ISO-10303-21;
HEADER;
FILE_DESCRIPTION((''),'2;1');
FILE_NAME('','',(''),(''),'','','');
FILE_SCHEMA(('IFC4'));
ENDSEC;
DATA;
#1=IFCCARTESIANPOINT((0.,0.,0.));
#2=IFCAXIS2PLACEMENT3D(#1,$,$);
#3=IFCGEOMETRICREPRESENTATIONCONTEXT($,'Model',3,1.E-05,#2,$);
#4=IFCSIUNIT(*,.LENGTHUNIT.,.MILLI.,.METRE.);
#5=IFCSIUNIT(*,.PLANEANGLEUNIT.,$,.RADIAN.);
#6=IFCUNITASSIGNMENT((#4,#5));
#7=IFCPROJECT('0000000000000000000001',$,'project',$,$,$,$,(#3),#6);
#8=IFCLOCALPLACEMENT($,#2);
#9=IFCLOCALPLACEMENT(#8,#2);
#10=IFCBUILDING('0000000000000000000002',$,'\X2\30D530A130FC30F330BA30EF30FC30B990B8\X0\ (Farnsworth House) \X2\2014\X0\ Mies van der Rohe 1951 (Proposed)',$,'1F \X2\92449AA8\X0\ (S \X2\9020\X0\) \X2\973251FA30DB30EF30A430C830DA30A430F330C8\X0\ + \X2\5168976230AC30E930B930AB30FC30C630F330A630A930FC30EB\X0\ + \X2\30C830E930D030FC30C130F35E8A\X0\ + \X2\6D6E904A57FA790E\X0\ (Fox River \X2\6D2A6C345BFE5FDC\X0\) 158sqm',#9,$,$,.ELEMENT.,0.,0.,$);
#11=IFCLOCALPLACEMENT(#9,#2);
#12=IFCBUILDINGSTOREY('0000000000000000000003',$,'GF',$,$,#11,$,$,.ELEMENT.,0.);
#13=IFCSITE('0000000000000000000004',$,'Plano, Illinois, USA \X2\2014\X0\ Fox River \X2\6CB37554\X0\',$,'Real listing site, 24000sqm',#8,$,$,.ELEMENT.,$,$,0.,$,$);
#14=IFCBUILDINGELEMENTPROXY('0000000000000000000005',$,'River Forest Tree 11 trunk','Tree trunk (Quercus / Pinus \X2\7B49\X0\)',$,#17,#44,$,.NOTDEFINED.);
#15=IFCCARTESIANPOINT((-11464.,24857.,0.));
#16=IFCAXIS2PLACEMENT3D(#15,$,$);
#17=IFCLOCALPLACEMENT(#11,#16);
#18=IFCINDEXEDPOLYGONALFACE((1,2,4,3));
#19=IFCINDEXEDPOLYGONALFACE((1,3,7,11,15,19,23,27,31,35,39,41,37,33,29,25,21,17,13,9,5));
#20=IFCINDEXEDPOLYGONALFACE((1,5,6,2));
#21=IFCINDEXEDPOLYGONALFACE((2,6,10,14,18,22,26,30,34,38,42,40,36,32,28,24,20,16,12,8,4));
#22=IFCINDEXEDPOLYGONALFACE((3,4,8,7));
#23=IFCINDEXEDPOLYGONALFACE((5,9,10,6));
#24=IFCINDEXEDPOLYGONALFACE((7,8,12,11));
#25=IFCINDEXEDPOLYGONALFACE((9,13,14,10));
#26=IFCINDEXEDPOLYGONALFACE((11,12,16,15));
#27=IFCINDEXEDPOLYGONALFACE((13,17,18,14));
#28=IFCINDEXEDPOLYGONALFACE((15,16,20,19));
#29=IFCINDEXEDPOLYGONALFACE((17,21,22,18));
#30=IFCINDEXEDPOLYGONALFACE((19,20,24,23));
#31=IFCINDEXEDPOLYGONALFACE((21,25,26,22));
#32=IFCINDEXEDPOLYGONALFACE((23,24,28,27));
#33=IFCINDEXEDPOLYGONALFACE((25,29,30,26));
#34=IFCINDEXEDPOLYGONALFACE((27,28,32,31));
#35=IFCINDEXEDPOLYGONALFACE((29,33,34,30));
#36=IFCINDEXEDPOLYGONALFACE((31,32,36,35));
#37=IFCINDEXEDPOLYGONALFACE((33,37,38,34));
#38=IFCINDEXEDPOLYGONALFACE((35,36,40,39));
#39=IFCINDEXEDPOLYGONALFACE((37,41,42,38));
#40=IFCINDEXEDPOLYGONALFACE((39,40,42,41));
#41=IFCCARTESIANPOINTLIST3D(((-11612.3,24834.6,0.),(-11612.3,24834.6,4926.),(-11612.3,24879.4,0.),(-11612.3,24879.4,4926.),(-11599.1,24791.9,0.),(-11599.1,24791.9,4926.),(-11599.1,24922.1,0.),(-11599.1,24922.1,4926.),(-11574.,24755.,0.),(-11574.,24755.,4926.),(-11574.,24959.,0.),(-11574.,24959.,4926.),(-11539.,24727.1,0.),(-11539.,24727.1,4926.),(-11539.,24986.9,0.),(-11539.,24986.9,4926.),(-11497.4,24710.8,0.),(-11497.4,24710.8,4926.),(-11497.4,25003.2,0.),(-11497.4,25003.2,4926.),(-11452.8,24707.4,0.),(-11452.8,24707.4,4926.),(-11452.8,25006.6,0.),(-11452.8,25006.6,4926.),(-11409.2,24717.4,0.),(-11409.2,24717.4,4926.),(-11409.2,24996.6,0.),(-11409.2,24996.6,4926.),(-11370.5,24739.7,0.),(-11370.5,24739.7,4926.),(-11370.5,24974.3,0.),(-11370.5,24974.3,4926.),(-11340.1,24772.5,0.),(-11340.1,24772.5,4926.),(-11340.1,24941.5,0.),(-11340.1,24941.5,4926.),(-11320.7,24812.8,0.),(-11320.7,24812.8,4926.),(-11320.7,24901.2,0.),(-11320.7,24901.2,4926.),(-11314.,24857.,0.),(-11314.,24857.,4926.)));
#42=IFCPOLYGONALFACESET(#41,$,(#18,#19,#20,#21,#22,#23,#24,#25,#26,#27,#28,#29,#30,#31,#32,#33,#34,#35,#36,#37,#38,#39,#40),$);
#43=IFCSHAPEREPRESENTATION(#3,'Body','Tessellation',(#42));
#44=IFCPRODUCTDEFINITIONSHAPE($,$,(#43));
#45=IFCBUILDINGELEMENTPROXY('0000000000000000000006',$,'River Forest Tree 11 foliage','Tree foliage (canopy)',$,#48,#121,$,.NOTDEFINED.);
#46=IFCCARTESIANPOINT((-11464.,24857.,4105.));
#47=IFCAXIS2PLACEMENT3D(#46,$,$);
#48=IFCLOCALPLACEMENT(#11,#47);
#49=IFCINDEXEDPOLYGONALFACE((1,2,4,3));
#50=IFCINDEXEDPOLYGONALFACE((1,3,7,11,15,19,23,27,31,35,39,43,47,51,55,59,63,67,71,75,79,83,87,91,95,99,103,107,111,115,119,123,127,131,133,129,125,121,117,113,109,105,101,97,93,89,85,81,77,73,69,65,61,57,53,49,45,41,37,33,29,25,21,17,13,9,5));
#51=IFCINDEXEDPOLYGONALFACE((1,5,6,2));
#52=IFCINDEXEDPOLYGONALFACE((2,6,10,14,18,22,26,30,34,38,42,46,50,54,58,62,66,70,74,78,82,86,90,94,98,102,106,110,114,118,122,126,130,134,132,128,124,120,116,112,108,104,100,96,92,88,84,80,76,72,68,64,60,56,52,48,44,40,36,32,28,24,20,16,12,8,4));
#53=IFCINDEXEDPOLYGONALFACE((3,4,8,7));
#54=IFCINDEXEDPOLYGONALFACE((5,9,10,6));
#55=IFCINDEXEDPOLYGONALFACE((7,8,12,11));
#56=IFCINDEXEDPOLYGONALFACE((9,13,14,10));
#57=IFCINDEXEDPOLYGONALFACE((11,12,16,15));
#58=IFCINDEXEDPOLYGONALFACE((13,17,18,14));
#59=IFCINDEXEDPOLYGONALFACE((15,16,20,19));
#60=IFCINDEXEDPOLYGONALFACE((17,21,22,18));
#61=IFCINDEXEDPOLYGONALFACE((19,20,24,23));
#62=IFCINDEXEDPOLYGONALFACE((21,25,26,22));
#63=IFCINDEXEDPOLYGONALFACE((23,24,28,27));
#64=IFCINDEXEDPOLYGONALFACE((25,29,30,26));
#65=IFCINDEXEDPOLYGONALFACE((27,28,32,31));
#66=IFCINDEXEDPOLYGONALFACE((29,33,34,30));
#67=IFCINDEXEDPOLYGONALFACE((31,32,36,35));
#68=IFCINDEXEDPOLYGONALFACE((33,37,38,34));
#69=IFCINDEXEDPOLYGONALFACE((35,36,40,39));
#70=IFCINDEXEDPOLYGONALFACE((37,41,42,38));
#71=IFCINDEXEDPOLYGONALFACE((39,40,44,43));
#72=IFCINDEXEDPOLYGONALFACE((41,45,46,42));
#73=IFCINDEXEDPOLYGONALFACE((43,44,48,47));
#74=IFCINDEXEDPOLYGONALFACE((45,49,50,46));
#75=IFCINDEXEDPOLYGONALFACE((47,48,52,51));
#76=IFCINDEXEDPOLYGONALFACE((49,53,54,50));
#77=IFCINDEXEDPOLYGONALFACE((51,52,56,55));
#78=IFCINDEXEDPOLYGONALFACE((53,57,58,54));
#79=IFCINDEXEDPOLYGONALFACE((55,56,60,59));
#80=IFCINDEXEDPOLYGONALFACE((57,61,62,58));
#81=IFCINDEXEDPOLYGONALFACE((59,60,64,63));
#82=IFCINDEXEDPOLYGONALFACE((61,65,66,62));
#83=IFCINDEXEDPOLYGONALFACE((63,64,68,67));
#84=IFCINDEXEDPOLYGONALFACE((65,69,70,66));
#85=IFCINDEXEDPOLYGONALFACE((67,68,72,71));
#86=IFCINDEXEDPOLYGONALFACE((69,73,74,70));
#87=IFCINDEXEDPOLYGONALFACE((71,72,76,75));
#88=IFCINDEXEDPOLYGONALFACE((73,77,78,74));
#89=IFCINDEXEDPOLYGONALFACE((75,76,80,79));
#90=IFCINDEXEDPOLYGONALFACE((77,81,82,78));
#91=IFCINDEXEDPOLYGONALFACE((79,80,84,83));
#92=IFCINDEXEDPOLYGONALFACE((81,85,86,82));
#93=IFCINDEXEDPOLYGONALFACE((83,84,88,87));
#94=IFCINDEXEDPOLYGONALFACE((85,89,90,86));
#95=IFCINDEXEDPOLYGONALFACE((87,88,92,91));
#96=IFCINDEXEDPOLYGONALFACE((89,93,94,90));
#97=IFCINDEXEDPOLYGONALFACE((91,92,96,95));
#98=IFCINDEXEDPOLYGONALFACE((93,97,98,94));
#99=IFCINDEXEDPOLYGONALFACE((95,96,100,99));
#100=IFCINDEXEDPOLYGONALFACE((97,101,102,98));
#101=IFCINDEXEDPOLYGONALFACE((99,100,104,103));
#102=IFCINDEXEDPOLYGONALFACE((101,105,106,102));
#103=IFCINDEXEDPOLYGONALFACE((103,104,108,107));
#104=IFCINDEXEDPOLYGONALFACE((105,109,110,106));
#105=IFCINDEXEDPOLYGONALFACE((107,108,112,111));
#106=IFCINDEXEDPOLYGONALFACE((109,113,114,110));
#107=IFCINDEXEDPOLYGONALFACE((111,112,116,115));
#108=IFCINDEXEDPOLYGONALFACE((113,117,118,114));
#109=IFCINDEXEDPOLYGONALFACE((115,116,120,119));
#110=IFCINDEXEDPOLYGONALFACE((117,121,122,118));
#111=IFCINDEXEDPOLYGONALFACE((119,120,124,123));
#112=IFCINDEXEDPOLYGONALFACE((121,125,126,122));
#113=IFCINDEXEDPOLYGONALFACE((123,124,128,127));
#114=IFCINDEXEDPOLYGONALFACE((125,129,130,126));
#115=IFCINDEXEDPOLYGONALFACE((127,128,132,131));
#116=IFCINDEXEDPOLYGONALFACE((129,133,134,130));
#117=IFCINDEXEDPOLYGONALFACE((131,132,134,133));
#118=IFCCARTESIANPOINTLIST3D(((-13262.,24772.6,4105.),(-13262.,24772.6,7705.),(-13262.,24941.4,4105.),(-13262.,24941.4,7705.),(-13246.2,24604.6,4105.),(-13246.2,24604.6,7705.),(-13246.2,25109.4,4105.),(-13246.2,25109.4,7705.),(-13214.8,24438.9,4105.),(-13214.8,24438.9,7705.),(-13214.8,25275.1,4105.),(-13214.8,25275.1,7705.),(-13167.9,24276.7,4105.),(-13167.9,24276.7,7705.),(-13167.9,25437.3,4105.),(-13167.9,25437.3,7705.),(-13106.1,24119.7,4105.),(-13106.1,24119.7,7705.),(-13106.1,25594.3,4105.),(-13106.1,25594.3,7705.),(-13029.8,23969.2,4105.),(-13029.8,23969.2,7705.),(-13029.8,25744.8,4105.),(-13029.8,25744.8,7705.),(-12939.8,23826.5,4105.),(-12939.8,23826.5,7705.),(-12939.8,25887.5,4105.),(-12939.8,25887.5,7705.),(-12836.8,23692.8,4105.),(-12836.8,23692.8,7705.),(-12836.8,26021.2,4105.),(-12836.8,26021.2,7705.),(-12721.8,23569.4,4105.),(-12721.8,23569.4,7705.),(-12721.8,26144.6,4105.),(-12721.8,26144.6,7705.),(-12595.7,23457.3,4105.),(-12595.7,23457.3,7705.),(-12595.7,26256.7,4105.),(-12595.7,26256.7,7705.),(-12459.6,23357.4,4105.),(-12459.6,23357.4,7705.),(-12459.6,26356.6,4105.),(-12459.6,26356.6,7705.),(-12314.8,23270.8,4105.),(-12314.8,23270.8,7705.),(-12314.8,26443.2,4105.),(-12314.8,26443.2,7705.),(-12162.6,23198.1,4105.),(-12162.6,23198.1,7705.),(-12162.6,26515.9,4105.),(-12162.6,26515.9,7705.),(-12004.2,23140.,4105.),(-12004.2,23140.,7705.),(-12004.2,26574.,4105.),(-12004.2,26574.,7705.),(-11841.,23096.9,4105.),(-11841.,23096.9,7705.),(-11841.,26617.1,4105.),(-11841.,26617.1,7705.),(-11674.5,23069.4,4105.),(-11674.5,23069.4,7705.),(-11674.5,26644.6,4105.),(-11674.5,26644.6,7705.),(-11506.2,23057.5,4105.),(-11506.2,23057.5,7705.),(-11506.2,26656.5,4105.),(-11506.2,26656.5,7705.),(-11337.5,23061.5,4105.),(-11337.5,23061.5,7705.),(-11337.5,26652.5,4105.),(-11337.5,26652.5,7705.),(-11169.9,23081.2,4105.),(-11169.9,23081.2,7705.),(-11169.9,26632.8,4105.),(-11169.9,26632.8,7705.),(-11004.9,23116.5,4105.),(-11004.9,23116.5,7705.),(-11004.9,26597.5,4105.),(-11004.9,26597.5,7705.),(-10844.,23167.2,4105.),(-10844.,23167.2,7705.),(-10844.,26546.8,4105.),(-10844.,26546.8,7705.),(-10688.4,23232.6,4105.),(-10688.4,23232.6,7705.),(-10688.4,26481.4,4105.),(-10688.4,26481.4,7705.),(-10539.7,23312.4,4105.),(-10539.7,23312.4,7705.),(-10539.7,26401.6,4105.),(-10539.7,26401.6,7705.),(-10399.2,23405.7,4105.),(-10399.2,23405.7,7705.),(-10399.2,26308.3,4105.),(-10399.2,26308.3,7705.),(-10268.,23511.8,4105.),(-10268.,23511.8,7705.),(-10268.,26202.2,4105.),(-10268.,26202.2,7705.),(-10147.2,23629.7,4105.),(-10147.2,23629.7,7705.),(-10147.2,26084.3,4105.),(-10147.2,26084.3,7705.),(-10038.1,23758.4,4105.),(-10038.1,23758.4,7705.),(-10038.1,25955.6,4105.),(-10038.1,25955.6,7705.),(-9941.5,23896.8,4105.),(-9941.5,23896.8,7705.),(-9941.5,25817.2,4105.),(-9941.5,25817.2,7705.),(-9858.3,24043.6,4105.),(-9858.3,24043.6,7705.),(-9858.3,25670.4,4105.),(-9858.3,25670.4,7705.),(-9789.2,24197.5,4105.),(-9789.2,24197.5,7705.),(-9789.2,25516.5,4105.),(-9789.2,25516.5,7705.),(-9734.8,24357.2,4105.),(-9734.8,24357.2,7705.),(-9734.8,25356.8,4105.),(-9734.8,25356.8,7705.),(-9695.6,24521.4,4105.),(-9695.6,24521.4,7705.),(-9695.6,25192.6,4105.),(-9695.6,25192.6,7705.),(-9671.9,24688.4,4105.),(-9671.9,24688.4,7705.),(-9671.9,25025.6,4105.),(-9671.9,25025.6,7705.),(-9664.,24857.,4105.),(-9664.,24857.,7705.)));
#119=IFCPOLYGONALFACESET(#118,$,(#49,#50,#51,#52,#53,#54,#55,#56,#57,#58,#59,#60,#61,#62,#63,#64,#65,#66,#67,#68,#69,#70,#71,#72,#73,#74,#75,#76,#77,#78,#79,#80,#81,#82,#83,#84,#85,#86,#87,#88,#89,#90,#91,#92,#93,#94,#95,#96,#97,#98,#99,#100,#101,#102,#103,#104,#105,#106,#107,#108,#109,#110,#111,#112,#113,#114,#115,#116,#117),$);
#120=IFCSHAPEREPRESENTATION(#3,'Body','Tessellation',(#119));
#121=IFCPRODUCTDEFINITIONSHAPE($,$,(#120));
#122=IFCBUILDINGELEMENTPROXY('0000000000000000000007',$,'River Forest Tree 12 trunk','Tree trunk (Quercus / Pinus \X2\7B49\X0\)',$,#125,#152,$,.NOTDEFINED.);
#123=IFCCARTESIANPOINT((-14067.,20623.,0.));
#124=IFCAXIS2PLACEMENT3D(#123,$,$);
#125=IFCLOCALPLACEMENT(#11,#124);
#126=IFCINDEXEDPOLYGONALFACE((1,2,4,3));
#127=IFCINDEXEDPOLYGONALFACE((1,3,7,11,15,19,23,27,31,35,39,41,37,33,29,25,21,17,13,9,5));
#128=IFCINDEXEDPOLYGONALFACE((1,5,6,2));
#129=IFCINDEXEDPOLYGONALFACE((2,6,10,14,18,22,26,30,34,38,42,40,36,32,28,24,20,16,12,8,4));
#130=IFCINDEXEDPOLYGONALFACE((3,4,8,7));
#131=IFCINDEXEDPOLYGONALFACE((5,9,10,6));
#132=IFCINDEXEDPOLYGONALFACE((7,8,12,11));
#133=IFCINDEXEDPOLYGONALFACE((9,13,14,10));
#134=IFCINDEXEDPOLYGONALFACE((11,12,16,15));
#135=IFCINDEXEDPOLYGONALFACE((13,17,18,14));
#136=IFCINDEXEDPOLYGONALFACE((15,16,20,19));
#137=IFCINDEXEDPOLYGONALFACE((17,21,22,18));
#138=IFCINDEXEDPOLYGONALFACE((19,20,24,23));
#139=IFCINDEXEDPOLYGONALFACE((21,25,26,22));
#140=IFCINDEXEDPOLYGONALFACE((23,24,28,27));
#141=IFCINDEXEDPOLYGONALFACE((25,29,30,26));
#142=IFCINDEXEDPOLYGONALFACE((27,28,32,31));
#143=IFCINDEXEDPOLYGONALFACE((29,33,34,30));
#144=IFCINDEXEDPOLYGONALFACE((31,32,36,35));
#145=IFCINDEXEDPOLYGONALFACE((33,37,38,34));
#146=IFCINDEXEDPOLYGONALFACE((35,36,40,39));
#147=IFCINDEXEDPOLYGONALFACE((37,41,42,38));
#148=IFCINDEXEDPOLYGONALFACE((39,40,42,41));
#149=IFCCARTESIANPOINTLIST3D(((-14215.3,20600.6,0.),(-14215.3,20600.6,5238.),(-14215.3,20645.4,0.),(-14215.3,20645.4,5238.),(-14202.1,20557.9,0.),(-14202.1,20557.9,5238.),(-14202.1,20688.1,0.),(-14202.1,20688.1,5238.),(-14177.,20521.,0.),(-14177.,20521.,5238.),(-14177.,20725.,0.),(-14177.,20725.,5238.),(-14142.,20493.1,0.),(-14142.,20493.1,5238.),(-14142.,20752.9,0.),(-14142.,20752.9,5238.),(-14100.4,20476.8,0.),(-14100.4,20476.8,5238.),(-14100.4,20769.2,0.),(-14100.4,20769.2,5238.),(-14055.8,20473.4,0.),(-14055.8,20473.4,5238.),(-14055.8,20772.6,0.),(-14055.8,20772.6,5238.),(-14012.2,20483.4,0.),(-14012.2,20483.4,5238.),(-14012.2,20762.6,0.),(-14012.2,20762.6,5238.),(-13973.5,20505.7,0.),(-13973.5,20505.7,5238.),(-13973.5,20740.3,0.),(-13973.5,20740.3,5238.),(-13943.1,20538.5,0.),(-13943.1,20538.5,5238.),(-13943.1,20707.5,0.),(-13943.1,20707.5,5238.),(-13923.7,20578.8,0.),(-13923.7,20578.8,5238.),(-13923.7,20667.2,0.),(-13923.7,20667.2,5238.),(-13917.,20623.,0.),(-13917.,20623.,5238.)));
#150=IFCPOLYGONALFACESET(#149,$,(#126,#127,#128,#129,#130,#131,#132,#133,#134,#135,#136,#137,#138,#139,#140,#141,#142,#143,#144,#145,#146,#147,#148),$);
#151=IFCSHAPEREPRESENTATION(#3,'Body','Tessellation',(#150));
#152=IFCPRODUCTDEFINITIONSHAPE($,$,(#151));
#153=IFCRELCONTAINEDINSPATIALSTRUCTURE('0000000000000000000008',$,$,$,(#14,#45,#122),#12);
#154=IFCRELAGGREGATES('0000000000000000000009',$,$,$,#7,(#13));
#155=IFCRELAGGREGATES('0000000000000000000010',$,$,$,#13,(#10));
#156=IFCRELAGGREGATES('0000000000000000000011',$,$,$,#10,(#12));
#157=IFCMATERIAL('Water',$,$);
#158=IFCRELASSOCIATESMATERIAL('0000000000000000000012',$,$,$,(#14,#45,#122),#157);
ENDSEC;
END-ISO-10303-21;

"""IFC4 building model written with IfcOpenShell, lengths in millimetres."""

from ifc_helpers import new_model, si_unit, frame, origin, origin_2d, place, context, project, spatial, circle, extrude, material, element, save


model = new_model("IFC4")

# Units and contexts
model_context = context("Model", 3, precision=1e-05, world=origin())
ifc_project = project(units=[si_unit("LENGTHUNIT", "METRE", prefix="MILLI"), si_unit("PLANEANGLEUNIT", "RADIAN")], contexts=[model_context])

# Site, building, storey
site_placement = place(None, origin())
site = spatial("IfcSite", under=ifc_project, at=site_placement, Name="Plano, Illinois, USA — Fox River 河畔", ObjectType="Real listing site, 24000sqm", CompositionType="ELEMENT", RefElevation=0.0)
building_placement = place(site_placement, origin())
building = spatial("IfcBuilding", under=site, at=building_placement, Name="ファーンズワース邸 (Farnsworth House) — Mies van der Rohe 1951 (Proposed)", ObjectType="1F 鉄骨 (S 造) 露出ホワイトペイント + 全面ガラスカーテンウォール + トラバーチン床 + 浮遊基礎 (Fox River 洪水対応) 158sqm", CompositionType="ELEMENT", ElevationOfRefHeight=0.0, ElevationOfTerrain=0.0)
storey_placement = place(building_placement, origin())
storey = spatial("IfcBuildingStorey", under=building, at=storey_placement, Name="GF", CompositionType="ELEMENT", Elevation=0.0)

# Building element proxies
ifc_material_1 = material(Name="Water")
proxy_1_placement = place(storey_placement, frame((-11464.0, 24857.0, 0.0)))
element("IfcBuildingElementProxy", 1, at=proxy_1_placement, inside=storey, material=ifc_material_1, Name="River Forest Tree 11 trunk", Description="Tree trunk (Quercus / Pinus 等)", PredefinedType="NOTDEFINED", context=model_context, shape_type="SweptSolid", body=[
    extrude(circle(Radius=150.0, at=origin_2d()), frame((-11464.0, 24857.0, 0.0)), (0.0, 0.0, 1.0), 4926.0),
])
proxy_2_placement = place(storey_placement, frame((-11464.0, 24857.0, 4105.0)))
element("IfcBuildingElementProxy", 2, at=proxy_2_placement, inside=storey, material=ifc_material_1, Name="River Forest Tree 11 foliage", Description="Tree foliage (canopy)", PredefinedType="NOTDEFINED", context=model_context, shape_type="SweptSolid", body=[
    extrude(circle(Radius=1800.0, at=origin_2d()), frame((-11464.0, 24857.0, 4105.0)), (0.0, 0.0, 1.0), 3600.0),
])
proxy_3_placement = place(storey_placement, frame((-14067.0, 20623.0, 0.0)))
element("IfcBuildingElementProxy", 3, at=proxy_3_placement, inside=storey, material=ifc_material_1, Name="River Forest Tree 12 trunk", Description="Tree trunk (Quercus / Pinus 等)", PredefinedType="NOTDEFINED", context=model_context, shape_type="SweptSolid", body=[
    extrude(circle(Radius=150.0, at=origin_2d()), frame((-14067.0, 20623.0, 0.0)), (0.0, 0.0, 1.0), 5238.0),
])

save(model, "model.ifc")
